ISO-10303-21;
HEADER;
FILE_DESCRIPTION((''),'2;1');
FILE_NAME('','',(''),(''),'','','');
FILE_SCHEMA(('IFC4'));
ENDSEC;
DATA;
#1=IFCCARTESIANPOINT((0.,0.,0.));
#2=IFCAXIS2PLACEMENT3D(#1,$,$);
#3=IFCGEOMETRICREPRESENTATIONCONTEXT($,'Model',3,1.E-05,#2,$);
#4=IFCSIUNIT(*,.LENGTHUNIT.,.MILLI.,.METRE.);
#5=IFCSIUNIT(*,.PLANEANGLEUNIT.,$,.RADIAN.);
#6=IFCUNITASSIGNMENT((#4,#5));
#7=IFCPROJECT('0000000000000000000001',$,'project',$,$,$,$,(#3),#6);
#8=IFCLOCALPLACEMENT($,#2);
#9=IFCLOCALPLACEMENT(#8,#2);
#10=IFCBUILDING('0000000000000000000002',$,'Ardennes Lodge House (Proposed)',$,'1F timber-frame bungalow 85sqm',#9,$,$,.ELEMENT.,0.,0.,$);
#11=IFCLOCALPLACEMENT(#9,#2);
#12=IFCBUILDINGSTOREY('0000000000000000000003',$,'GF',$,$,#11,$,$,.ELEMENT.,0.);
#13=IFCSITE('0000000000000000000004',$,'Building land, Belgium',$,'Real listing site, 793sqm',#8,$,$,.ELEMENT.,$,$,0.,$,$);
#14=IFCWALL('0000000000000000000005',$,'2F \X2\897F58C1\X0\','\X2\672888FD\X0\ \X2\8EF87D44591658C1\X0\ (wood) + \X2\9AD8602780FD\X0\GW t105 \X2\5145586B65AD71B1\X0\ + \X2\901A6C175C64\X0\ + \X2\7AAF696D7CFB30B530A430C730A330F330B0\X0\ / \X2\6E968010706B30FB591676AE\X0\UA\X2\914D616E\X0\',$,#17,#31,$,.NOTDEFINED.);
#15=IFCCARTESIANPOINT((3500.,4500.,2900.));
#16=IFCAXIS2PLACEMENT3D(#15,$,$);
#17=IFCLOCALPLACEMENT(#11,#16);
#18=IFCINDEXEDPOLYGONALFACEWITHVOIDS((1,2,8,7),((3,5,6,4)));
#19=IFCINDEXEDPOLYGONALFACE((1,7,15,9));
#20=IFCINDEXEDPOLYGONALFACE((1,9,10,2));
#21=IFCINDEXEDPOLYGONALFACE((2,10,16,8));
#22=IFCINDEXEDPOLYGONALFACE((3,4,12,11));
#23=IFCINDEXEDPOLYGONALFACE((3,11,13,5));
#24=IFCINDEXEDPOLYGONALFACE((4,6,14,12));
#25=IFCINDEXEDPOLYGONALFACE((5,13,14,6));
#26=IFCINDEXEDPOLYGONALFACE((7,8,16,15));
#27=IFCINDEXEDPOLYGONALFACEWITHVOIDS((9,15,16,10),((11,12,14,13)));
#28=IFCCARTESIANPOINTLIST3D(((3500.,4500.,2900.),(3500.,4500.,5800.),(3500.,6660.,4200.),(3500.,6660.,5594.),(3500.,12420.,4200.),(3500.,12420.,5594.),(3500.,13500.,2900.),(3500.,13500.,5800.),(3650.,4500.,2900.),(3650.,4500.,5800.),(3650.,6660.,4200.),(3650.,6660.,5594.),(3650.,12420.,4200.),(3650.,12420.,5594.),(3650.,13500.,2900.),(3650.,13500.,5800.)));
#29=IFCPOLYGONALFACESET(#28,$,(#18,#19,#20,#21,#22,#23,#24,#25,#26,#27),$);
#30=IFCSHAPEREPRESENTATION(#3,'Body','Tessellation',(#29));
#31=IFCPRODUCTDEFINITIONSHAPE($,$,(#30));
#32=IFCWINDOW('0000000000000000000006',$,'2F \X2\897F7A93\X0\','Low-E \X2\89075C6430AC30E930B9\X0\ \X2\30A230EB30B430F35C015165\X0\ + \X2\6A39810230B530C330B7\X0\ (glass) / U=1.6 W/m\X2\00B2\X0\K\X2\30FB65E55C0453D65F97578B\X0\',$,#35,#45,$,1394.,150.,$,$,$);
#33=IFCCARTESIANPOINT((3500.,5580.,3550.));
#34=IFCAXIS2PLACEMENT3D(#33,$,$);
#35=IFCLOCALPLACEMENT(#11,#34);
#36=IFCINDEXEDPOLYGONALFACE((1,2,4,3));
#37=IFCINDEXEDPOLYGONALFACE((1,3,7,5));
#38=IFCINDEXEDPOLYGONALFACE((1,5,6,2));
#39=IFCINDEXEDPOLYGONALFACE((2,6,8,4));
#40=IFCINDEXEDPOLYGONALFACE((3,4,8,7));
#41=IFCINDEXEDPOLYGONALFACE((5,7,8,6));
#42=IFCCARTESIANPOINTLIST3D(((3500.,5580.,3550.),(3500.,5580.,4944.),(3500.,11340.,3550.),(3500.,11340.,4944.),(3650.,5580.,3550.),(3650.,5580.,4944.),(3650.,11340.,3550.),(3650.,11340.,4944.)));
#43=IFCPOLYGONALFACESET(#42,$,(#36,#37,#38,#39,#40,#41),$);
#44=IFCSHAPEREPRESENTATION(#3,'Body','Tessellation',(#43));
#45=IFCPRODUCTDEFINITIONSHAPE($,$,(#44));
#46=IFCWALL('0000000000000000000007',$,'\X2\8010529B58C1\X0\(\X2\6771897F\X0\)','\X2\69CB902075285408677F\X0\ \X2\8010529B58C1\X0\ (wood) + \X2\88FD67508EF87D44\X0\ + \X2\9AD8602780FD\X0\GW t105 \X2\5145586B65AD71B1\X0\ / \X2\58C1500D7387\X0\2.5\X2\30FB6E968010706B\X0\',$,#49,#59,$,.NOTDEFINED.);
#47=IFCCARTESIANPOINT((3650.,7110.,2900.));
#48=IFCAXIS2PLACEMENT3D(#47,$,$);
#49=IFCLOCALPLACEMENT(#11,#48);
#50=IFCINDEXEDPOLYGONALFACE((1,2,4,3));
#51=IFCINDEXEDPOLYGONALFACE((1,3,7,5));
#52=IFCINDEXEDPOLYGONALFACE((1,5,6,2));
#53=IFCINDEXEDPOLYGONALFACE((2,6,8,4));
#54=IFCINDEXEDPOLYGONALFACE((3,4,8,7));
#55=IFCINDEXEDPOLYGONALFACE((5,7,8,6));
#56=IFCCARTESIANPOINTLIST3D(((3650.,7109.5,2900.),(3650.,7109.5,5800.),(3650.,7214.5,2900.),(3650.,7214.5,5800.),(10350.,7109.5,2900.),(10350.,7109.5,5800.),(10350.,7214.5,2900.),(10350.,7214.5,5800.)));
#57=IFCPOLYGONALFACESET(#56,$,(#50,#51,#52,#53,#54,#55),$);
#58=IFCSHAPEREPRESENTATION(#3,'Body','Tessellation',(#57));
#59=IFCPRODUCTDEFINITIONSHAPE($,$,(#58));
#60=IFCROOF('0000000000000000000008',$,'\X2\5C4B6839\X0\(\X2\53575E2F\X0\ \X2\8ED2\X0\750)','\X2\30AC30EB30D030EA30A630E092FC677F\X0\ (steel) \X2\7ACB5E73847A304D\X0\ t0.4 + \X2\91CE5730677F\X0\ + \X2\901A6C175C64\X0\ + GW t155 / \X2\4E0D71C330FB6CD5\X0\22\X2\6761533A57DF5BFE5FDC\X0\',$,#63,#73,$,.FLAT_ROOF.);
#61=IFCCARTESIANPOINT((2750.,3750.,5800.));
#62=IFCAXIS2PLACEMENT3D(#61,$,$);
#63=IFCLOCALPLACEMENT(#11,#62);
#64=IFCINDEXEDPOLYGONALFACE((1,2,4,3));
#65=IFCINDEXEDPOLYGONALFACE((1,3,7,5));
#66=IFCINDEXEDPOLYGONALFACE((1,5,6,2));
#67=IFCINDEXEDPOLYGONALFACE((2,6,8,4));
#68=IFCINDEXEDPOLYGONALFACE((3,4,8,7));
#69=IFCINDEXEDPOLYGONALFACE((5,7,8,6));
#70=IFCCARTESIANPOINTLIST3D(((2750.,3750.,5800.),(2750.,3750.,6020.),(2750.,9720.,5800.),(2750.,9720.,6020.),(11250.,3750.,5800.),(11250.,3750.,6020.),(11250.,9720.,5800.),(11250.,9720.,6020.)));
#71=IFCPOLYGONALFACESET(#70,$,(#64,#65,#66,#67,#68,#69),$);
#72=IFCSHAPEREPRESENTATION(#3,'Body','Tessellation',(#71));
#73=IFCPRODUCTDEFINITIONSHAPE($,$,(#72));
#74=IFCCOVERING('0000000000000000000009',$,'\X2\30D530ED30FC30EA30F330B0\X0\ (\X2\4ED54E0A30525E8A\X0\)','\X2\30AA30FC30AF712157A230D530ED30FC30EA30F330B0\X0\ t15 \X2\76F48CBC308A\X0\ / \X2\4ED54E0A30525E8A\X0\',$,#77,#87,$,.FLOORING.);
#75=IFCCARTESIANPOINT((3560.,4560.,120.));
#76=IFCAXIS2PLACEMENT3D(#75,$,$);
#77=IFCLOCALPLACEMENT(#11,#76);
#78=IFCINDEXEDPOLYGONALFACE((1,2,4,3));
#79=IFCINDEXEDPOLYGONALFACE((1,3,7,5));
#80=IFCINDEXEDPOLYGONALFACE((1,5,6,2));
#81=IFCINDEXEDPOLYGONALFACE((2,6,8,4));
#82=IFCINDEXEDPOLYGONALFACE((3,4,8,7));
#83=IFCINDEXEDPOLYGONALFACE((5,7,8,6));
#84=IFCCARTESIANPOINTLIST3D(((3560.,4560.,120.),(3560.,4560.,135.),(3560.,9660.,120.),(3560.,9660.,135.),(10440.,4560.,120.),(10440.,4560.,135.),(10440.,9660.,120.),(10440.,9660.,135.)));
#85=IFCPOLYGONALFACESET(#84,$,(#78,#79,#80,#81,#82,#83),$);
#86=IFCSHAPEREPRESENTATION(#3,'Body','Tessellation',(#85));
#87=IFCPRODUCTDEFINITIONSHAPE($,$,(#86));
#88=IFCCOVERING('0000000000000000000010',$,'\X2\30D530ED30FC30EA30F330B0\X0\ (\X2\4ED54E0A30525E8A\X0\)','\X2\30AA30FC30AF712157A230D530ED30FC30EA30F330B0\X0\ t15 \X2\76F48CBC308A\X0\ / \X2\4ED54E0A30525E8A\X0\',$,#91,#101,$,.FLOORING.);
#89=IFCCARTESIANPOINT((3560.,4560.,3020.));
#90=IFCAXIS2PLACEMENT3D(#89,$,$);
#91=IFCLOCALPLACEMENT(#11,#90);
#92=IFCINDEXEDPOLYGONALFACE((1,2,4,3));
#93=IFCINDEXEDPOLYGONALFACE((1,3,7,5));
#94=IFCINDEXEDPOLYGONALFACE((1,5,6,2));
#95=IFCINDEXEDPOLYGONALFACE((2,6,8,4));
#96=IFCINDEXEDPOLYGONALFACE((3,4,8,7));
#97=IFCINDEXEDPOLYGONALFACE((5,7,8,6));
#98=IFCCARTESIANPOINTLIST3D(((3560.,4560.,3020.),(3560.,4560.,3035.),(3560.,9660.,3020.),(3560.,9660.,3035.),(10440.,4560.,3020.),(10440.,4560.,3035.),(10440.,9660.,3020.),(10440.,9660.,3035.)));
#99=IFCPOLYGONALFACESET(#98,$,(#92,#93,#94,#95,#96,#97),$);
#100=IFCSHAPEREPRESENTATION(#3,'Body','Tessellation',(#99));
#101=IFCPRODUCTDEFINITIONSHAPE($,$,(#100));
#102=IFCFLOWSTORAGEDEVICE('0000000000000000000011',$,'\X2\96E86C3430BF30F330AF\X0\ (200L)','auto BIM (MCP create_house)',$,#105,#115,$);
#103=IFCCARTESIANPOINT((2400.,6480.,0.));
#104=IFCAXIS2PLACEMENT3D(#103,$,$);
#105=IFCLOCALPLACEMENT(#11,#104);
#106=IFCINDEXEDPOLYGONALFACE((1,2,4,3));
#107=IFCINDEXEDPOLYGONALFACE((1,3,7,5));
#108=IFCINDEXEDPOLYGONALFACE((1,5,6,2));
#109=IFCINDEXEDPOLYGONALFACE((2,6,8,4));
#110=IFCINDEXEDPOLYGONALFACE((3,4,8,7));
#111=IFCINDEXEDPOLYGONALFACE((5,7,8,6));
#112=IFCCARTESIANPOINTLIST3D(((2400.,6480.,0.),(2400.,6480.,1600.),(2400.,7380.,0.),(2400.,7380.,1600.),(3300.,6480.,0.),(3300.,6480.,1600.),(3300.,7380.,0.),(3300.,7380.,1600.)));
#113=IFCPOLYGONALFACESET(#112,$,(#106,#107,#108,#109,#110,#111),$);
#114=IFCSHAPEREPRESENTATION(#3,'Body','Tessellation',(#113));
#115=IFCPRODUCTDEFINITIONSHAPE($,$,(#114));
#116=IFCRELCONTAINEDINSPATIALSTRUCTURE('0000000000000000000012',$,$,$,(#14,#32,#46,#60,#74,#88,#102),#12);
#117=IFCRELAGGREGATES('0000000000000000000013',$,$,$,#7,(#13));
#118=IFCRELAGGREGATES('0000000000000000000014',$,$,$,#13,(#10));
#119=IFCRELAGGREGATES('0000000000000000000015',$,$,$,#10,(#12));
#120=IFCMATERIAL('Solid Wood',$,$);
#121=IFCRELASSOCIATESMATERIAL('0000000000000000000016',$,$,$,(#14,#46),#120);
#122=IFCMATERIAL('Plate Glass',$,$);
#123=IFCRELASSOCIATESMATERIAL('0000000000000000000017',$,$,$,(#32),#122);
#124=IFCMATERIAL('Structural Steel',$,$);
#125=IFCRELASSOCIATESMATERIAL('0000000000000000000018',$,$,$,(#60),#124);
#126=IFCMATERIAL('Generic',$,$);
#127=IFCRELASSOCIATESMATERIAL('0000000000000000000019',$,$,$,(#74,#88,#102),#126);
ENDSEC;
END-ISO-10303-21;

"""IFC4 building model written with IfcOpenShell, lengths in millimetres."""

from ifc_helpers import new_model, si_unit, frame, frame_2d, origin, place, context, project, spatial, rectangle, extrude, material, element, fill, save


model = new_model("IFC4")

# Units and contexts
model_context = context("Model", 3, precision=1e-05, world=origin())
ifc_project = project(units=[si_unit("LENGTHUNIT", "METRE", prefix="MILLI"), si_unit("PLANEANGLEUNIT", "RADIAN")], contexts=[model_context])

# Site, building, storey
site_placement = place(None, origin())
site = spatial("IfcSite", under=ifc_project, at=site_placement, Name="Building land, Belgium", ObjectType="Real listing site, 793sqm", CompositionType="ELEMENT", RefElevation=0.0)
building_placement = place(site_placement, origin())
building = spatial("IfcBuilding", under=site, at=building_placement, Name="Ardennes Lodge House (Proposed)", ObjectType="1F timber-frame bungalow 85sqm", CompositionType="ELEMENT", ElevationOfRefHeight=0.0, ElevationOfTerrain=0.0)
storey_placement = place(building_placement, origin())
storey = spatial("IfcBuildingStorey", under=building, at=storey_placement, Name="GF", CompositionType="ELEMENT", Elevation=0.0)

# Shared definitions
ifc_material_1 = material(Name="Solid Wood")
ifc_material_2 = material(Name="Generic")

# Shared definitions
ifc_material_3 = material(Name="Plate Glass")

# Wall, opening, window
wall_1_placement = place(storey_placement, frame((3500.0, 4500.0, 2900.0)))
wall_1 = element("IfcWall", 1, at=wall_1_placement, inside=storey, material=ifc_material_1, Name="2F 西壁", Description="木製 軸組外壁 (wood) + 高性能GW t105 充填断熱 + 通気層 + 窯業系サイディング / 準耐火・外皮UA配慮", PredefinedType="NOTDEFINED", context=model_context, shape_type="SweptSolid", body=[
    extrude(rectangle(XDim=150.0, YDim=9000.0, at=frame_2d((75.0, 4500.0))), frame((3500.0, 4500.0, 2900.0)), (0.0, 0.0, 1.0), 2900.0),
])
opening_1_placement = place(storey_placement, frame((3500.0, 5580.0, 3550.0)))
opening_1 = element("IfcOpeningElement", 2, at=opening_1_placement, cuts=wall_1, PredefinedType="NOTDEFINED", context=model_context, shape_type="SweptSolid", body=[
    extrude(rectangle(XDim=150.0, YDim=5760.0, at=frame_2d((75.0, 2880.0))), frame((3500.0, 5580.0, 3550.0)), (0.0, 0.0, 1.0), 1394.0),
])
window_1_placement = place(storey_placement, frame((3500.0, 5580.0, 3550.0)))
window_1 = element("IfcWindow", 3, at=window_1_placement, inside=storey, material=ifc_material_3, Name="2F 西窓", Description="Low-E 複層ガラス アルゴン封入 + 樹脂サッシ (glass) / U=1.6 W/m²K・日射取得型", OverallHeight=1394.0, OverallWidth=150.0, context=model_context, shape_type="SweptSolid", body=[
    extrude(rectangle(XDim=150.0, YDim=5760.0, at=frame_2d((75.0, 2880.0))), frame((3500.0, 5580.0, 3550.0)), (0.0, 0.0, 1.0), 1394.0),
])
fill(opening_1, window_1)

# Wall
wall_2_placement = place(storey_placement, frame((3650.0, 7110.0, 2900.0)))
element("IfcWall", 4, at=wall_2_placement, inside=storey, material=ifc_material_1, Name="耐力壁(東西)", Description="構造用合板 耐力壁 (wood) + 製材軸組 + 高性能GW t105 充填断熱 / 壁倍率2.5・準耐火", PredefinedType="NOTDEFINED", context=model_context, shape_type="SweptSolid", body=[
    extrude(rectangle(XDim=6700.0, YDim=105.0, at=frame_2d((3350.0, 52.0))), frame((3650.0, 7110.0, 2900.0)), (0.0, 0.0, 1.0), 2900.0),
])

# Roof
ifc_material_4 = material(Name="Structural Steel")
for number, where, name in (
    (5, (2750.0, 3750.0, 5800.0), "屋根(南帯 軒750)"),
):
    element("IfcRoof", number, at=place(storey_placement, frame(where)), inside=storey, material=ifc_material_4, Name=name, Description="ガルバリウム鋼板 (steel) 立平葺き t0.4 + 野地板 + 通気層 + GW t155 / 不燃・法22条区域対応", PredefinedType="FLAT_ROOF", context=model_context, shape_type="SweptSolid", body=[
        extrude(rectangle(XDim=8500.0, YDim=5970.0, at=frame_2d((4250.0, 2985.0))), frame((2750.0, 3750.0, 5800.0)), (0.0, 0.0, 1.0), 220.0),
    ])

# Coverings
covering_1_placement = place(storey_placement, frame((3560.0, 4560.0, 120.0)))
element("IfcCovering", 6, at=covering_1_placement, inside=storey, material=ifc_material_2, Name="フローリング (仕上げ床)", Description="オーク無垢フローリング t15 直貼り / 仕上げ床", PredefinedType="FLOORING", context=model_context, shape_type="SweptSolid", body=[
    extrude(rectangle(XDim=6880.0, YDim=5100.0, at=frame_2d((3440.0, 2550.0))), frame((3560.0, 4560.0, 120.0)), (0.0, 0.0, 1.0), 15.0),
])
covering_2_placement = place(storey_placement, frame((3560.0, 4560.0, 3020.0)))
element("IfcCovering", 7, at=covering_2_placement, inside=storey, material=ifc_material_2, Name="フローリング (仕上げ床)", Description="オーク無垢フローリング t15 直貼り / 仕上げ床", PredefinedType="FLOORING", context=model_context, shape_type="SweptSolid", body=[
    extrude(rectangle(XDim=6880.0, YDim=5100.0, at=frame_2d((3440.0, 2550.0))), frame((3560.0, 4560.0, 3020.0)), (0.0, 0.0, 1.0), 15.0),
])

# Flow storage device
flow_storage_device_placement = place(storey_placement, frame((2400.0, 6480.0, 0.0)))
element("IfcFlowStorageDevice", 8, at=flow_storage_device_placement, inside=storey, material=ifc_material_2, Name="雨水タンク (200L)", Description="auto BIM (MCP create_house)", context=model_context, shape_type="SweptSolid", body=[
    extrude(rectangle(XDim=900.0, YDim=900.0, at=frame_2d((450.0, 450.0))), frame((2400.0, 6480.0, 0.0)), (0.0, 0.0, 1.0), 1600.0),
])

save(model, "model.ifc")
